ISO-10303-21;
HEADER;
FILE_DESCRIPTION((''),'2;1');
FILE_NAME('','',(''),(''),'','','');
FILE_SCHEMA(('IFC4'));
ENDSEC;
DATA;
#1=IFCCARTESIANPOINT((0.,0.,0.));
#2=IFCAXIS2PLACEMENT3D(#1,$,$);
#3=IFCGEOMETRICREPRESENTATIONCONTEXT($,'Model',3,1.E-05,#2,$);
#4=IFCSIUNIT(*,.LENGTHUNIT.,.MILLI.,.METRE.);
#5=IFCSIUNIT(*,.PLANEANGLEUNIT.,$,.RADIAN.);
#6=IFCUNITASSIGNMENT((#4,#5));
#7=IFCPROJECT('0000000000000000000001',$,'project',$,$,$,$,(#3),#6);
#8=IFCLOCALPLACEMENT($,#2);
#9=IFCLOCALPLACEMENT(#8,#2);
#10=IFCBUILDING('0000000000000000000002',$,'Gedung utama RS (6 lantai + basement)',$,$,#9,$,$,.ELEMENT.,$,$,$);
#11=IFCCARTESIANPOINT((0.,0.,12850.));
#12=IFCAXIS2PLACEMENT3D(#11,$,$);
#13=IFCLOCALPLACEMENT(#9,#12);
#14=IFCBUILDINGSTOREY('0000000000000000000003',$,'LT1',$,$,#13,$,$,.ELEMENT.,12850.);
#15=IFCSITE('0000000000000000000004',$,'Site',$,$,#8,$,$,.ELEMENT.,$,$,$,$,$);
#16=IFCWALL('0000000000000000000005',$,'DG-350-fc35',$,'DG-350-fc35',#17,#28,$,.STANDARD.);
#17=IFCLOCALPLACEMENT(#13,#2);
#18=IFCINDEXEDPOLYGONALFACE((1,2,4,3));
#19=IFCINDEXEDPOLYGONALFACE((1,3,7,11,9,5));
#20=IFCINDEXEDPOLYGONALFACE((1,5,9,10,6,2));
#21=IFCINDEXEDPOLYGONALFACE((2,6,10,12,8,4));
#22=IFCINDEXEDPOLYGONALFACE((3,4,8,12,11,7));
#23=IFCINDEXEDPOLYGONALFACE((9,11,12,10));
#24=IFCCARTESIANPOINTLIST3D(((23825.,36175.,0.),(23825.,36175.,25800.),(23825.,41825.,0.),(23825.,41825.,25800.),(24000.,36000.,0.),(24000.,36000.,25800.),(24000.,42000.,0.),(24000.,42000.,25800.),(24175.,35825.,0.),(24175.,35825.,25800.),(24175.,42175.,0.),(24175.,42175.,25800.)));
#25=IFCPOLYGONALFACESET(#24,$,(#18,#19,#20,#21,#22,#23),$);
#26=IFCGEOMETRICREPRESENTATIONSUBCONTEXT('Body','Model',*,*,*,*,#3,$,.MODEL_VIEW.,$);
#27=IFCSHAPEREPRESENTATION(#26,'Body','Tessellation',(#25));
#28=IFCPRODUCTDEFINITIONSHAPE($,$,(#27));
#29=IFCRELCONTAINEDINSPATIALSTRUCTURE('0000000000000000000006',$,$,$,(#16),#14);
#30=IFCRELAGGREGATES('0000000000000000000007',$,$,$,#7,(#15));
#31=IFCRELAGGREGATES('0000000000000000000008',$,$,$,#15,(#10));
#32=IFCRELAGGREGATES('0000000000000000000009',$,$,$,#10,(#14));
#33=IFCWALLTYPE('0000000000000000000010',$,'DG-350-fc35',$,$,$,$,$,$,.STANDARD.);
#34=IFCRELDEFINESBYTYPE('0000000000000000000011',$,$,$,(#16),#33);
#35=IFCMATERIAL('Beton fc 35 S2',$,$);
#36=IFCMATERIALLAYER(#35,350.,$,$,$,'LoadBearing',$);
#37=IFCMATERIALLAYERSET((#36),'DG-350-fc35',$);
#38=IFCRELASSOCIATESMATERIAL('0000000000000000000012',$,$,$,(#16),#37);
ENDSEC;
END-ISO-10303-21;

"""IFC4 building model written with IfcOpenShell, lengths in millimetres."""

from ifc_helpers import new_model, si_unit, frame, origin, place, context, subcontext, project, spatial, polyline, outline, extrude, material, layer, layer_set, layer_usage, type_object, element, save


model = new_model("IFC4")

# Units and contexts
model_context = context("Model", 3, precision=1e-05, world=origin())
body_context = subcontext(model_context, "Body", "Model", "MODEL_VIEW")
ifc_project = project(units=[si_unit("LENGTHUNIT", "METRE", prefix="MILLI"), si_unit("PLANEANGLEUNIT", "RADIAN")], contexts=[model_context])

# Site, building, storey
site_placement = place(None, origin())
site = spatial("IfcSite", under=ifc_project, at=site_placement, Name="Site", CompositionType="ELEMENT")
building_placement = place(site_placement, origin())
building = spatial("IfcBuilding", under=site, at=building_placement, Name="Gedung utama RS (6 lantai + basement)", CompositionType="ELEMENT")
storey_placement = place(building_placement, frame((0.0, 0.0, 12850.0)))
storey = spatial("IfcBuildingStorey", under=building, at=storey_placement, Name="LT1", CompositionType="ELEMENT", Elevation=12850.0)

# Wall
ifc_material_1 = material(Name="Beton fc 35 S2")
ifc_layer_1 = layer(ifc_material_1, 350.0, Category="LoadBearing")
ifc_layer_set_1 = layer_set([ifc_layer_1], Name="DG-350-fc35")
ifc_layer_usage_1 = layer_usage(ifc_layer_set_1, "AXIS2", "NEGATIVE", 175.0)
wall_type = type_object("IfcWallType", Name="DG-350-fc35", PredefinedType="STANDARD")
wall_1_placement = place(storey_placement, frame((24000.0, 36000.0, 0.0), z_axis=(0.0, 0.0, 1.0), x_axis=(0.0, 1.0, 0.0)))
element("IfcWall", 1, at=wall_1_placement, inside=storey, type_object=wall_type, material=ifc_layer_usage_1, Name="DG-350-fc35", ObjectType="DG-350-fc35", PredefinedType="STANDARD", context=body_context, shape_type="SweptSolid", body=[
    extrude(outline(polyline([(-175.0, -175.0), (0.0, 0.0), (175.0, 175.0), (5825.0, 175.0), (6000.0, 0.0), (6175.0, -175.0), (-175.0, -175.0)])), origin(), (0.0, 0.0, 1.0), 25800.0),
])

save(model, "model.ifc")
